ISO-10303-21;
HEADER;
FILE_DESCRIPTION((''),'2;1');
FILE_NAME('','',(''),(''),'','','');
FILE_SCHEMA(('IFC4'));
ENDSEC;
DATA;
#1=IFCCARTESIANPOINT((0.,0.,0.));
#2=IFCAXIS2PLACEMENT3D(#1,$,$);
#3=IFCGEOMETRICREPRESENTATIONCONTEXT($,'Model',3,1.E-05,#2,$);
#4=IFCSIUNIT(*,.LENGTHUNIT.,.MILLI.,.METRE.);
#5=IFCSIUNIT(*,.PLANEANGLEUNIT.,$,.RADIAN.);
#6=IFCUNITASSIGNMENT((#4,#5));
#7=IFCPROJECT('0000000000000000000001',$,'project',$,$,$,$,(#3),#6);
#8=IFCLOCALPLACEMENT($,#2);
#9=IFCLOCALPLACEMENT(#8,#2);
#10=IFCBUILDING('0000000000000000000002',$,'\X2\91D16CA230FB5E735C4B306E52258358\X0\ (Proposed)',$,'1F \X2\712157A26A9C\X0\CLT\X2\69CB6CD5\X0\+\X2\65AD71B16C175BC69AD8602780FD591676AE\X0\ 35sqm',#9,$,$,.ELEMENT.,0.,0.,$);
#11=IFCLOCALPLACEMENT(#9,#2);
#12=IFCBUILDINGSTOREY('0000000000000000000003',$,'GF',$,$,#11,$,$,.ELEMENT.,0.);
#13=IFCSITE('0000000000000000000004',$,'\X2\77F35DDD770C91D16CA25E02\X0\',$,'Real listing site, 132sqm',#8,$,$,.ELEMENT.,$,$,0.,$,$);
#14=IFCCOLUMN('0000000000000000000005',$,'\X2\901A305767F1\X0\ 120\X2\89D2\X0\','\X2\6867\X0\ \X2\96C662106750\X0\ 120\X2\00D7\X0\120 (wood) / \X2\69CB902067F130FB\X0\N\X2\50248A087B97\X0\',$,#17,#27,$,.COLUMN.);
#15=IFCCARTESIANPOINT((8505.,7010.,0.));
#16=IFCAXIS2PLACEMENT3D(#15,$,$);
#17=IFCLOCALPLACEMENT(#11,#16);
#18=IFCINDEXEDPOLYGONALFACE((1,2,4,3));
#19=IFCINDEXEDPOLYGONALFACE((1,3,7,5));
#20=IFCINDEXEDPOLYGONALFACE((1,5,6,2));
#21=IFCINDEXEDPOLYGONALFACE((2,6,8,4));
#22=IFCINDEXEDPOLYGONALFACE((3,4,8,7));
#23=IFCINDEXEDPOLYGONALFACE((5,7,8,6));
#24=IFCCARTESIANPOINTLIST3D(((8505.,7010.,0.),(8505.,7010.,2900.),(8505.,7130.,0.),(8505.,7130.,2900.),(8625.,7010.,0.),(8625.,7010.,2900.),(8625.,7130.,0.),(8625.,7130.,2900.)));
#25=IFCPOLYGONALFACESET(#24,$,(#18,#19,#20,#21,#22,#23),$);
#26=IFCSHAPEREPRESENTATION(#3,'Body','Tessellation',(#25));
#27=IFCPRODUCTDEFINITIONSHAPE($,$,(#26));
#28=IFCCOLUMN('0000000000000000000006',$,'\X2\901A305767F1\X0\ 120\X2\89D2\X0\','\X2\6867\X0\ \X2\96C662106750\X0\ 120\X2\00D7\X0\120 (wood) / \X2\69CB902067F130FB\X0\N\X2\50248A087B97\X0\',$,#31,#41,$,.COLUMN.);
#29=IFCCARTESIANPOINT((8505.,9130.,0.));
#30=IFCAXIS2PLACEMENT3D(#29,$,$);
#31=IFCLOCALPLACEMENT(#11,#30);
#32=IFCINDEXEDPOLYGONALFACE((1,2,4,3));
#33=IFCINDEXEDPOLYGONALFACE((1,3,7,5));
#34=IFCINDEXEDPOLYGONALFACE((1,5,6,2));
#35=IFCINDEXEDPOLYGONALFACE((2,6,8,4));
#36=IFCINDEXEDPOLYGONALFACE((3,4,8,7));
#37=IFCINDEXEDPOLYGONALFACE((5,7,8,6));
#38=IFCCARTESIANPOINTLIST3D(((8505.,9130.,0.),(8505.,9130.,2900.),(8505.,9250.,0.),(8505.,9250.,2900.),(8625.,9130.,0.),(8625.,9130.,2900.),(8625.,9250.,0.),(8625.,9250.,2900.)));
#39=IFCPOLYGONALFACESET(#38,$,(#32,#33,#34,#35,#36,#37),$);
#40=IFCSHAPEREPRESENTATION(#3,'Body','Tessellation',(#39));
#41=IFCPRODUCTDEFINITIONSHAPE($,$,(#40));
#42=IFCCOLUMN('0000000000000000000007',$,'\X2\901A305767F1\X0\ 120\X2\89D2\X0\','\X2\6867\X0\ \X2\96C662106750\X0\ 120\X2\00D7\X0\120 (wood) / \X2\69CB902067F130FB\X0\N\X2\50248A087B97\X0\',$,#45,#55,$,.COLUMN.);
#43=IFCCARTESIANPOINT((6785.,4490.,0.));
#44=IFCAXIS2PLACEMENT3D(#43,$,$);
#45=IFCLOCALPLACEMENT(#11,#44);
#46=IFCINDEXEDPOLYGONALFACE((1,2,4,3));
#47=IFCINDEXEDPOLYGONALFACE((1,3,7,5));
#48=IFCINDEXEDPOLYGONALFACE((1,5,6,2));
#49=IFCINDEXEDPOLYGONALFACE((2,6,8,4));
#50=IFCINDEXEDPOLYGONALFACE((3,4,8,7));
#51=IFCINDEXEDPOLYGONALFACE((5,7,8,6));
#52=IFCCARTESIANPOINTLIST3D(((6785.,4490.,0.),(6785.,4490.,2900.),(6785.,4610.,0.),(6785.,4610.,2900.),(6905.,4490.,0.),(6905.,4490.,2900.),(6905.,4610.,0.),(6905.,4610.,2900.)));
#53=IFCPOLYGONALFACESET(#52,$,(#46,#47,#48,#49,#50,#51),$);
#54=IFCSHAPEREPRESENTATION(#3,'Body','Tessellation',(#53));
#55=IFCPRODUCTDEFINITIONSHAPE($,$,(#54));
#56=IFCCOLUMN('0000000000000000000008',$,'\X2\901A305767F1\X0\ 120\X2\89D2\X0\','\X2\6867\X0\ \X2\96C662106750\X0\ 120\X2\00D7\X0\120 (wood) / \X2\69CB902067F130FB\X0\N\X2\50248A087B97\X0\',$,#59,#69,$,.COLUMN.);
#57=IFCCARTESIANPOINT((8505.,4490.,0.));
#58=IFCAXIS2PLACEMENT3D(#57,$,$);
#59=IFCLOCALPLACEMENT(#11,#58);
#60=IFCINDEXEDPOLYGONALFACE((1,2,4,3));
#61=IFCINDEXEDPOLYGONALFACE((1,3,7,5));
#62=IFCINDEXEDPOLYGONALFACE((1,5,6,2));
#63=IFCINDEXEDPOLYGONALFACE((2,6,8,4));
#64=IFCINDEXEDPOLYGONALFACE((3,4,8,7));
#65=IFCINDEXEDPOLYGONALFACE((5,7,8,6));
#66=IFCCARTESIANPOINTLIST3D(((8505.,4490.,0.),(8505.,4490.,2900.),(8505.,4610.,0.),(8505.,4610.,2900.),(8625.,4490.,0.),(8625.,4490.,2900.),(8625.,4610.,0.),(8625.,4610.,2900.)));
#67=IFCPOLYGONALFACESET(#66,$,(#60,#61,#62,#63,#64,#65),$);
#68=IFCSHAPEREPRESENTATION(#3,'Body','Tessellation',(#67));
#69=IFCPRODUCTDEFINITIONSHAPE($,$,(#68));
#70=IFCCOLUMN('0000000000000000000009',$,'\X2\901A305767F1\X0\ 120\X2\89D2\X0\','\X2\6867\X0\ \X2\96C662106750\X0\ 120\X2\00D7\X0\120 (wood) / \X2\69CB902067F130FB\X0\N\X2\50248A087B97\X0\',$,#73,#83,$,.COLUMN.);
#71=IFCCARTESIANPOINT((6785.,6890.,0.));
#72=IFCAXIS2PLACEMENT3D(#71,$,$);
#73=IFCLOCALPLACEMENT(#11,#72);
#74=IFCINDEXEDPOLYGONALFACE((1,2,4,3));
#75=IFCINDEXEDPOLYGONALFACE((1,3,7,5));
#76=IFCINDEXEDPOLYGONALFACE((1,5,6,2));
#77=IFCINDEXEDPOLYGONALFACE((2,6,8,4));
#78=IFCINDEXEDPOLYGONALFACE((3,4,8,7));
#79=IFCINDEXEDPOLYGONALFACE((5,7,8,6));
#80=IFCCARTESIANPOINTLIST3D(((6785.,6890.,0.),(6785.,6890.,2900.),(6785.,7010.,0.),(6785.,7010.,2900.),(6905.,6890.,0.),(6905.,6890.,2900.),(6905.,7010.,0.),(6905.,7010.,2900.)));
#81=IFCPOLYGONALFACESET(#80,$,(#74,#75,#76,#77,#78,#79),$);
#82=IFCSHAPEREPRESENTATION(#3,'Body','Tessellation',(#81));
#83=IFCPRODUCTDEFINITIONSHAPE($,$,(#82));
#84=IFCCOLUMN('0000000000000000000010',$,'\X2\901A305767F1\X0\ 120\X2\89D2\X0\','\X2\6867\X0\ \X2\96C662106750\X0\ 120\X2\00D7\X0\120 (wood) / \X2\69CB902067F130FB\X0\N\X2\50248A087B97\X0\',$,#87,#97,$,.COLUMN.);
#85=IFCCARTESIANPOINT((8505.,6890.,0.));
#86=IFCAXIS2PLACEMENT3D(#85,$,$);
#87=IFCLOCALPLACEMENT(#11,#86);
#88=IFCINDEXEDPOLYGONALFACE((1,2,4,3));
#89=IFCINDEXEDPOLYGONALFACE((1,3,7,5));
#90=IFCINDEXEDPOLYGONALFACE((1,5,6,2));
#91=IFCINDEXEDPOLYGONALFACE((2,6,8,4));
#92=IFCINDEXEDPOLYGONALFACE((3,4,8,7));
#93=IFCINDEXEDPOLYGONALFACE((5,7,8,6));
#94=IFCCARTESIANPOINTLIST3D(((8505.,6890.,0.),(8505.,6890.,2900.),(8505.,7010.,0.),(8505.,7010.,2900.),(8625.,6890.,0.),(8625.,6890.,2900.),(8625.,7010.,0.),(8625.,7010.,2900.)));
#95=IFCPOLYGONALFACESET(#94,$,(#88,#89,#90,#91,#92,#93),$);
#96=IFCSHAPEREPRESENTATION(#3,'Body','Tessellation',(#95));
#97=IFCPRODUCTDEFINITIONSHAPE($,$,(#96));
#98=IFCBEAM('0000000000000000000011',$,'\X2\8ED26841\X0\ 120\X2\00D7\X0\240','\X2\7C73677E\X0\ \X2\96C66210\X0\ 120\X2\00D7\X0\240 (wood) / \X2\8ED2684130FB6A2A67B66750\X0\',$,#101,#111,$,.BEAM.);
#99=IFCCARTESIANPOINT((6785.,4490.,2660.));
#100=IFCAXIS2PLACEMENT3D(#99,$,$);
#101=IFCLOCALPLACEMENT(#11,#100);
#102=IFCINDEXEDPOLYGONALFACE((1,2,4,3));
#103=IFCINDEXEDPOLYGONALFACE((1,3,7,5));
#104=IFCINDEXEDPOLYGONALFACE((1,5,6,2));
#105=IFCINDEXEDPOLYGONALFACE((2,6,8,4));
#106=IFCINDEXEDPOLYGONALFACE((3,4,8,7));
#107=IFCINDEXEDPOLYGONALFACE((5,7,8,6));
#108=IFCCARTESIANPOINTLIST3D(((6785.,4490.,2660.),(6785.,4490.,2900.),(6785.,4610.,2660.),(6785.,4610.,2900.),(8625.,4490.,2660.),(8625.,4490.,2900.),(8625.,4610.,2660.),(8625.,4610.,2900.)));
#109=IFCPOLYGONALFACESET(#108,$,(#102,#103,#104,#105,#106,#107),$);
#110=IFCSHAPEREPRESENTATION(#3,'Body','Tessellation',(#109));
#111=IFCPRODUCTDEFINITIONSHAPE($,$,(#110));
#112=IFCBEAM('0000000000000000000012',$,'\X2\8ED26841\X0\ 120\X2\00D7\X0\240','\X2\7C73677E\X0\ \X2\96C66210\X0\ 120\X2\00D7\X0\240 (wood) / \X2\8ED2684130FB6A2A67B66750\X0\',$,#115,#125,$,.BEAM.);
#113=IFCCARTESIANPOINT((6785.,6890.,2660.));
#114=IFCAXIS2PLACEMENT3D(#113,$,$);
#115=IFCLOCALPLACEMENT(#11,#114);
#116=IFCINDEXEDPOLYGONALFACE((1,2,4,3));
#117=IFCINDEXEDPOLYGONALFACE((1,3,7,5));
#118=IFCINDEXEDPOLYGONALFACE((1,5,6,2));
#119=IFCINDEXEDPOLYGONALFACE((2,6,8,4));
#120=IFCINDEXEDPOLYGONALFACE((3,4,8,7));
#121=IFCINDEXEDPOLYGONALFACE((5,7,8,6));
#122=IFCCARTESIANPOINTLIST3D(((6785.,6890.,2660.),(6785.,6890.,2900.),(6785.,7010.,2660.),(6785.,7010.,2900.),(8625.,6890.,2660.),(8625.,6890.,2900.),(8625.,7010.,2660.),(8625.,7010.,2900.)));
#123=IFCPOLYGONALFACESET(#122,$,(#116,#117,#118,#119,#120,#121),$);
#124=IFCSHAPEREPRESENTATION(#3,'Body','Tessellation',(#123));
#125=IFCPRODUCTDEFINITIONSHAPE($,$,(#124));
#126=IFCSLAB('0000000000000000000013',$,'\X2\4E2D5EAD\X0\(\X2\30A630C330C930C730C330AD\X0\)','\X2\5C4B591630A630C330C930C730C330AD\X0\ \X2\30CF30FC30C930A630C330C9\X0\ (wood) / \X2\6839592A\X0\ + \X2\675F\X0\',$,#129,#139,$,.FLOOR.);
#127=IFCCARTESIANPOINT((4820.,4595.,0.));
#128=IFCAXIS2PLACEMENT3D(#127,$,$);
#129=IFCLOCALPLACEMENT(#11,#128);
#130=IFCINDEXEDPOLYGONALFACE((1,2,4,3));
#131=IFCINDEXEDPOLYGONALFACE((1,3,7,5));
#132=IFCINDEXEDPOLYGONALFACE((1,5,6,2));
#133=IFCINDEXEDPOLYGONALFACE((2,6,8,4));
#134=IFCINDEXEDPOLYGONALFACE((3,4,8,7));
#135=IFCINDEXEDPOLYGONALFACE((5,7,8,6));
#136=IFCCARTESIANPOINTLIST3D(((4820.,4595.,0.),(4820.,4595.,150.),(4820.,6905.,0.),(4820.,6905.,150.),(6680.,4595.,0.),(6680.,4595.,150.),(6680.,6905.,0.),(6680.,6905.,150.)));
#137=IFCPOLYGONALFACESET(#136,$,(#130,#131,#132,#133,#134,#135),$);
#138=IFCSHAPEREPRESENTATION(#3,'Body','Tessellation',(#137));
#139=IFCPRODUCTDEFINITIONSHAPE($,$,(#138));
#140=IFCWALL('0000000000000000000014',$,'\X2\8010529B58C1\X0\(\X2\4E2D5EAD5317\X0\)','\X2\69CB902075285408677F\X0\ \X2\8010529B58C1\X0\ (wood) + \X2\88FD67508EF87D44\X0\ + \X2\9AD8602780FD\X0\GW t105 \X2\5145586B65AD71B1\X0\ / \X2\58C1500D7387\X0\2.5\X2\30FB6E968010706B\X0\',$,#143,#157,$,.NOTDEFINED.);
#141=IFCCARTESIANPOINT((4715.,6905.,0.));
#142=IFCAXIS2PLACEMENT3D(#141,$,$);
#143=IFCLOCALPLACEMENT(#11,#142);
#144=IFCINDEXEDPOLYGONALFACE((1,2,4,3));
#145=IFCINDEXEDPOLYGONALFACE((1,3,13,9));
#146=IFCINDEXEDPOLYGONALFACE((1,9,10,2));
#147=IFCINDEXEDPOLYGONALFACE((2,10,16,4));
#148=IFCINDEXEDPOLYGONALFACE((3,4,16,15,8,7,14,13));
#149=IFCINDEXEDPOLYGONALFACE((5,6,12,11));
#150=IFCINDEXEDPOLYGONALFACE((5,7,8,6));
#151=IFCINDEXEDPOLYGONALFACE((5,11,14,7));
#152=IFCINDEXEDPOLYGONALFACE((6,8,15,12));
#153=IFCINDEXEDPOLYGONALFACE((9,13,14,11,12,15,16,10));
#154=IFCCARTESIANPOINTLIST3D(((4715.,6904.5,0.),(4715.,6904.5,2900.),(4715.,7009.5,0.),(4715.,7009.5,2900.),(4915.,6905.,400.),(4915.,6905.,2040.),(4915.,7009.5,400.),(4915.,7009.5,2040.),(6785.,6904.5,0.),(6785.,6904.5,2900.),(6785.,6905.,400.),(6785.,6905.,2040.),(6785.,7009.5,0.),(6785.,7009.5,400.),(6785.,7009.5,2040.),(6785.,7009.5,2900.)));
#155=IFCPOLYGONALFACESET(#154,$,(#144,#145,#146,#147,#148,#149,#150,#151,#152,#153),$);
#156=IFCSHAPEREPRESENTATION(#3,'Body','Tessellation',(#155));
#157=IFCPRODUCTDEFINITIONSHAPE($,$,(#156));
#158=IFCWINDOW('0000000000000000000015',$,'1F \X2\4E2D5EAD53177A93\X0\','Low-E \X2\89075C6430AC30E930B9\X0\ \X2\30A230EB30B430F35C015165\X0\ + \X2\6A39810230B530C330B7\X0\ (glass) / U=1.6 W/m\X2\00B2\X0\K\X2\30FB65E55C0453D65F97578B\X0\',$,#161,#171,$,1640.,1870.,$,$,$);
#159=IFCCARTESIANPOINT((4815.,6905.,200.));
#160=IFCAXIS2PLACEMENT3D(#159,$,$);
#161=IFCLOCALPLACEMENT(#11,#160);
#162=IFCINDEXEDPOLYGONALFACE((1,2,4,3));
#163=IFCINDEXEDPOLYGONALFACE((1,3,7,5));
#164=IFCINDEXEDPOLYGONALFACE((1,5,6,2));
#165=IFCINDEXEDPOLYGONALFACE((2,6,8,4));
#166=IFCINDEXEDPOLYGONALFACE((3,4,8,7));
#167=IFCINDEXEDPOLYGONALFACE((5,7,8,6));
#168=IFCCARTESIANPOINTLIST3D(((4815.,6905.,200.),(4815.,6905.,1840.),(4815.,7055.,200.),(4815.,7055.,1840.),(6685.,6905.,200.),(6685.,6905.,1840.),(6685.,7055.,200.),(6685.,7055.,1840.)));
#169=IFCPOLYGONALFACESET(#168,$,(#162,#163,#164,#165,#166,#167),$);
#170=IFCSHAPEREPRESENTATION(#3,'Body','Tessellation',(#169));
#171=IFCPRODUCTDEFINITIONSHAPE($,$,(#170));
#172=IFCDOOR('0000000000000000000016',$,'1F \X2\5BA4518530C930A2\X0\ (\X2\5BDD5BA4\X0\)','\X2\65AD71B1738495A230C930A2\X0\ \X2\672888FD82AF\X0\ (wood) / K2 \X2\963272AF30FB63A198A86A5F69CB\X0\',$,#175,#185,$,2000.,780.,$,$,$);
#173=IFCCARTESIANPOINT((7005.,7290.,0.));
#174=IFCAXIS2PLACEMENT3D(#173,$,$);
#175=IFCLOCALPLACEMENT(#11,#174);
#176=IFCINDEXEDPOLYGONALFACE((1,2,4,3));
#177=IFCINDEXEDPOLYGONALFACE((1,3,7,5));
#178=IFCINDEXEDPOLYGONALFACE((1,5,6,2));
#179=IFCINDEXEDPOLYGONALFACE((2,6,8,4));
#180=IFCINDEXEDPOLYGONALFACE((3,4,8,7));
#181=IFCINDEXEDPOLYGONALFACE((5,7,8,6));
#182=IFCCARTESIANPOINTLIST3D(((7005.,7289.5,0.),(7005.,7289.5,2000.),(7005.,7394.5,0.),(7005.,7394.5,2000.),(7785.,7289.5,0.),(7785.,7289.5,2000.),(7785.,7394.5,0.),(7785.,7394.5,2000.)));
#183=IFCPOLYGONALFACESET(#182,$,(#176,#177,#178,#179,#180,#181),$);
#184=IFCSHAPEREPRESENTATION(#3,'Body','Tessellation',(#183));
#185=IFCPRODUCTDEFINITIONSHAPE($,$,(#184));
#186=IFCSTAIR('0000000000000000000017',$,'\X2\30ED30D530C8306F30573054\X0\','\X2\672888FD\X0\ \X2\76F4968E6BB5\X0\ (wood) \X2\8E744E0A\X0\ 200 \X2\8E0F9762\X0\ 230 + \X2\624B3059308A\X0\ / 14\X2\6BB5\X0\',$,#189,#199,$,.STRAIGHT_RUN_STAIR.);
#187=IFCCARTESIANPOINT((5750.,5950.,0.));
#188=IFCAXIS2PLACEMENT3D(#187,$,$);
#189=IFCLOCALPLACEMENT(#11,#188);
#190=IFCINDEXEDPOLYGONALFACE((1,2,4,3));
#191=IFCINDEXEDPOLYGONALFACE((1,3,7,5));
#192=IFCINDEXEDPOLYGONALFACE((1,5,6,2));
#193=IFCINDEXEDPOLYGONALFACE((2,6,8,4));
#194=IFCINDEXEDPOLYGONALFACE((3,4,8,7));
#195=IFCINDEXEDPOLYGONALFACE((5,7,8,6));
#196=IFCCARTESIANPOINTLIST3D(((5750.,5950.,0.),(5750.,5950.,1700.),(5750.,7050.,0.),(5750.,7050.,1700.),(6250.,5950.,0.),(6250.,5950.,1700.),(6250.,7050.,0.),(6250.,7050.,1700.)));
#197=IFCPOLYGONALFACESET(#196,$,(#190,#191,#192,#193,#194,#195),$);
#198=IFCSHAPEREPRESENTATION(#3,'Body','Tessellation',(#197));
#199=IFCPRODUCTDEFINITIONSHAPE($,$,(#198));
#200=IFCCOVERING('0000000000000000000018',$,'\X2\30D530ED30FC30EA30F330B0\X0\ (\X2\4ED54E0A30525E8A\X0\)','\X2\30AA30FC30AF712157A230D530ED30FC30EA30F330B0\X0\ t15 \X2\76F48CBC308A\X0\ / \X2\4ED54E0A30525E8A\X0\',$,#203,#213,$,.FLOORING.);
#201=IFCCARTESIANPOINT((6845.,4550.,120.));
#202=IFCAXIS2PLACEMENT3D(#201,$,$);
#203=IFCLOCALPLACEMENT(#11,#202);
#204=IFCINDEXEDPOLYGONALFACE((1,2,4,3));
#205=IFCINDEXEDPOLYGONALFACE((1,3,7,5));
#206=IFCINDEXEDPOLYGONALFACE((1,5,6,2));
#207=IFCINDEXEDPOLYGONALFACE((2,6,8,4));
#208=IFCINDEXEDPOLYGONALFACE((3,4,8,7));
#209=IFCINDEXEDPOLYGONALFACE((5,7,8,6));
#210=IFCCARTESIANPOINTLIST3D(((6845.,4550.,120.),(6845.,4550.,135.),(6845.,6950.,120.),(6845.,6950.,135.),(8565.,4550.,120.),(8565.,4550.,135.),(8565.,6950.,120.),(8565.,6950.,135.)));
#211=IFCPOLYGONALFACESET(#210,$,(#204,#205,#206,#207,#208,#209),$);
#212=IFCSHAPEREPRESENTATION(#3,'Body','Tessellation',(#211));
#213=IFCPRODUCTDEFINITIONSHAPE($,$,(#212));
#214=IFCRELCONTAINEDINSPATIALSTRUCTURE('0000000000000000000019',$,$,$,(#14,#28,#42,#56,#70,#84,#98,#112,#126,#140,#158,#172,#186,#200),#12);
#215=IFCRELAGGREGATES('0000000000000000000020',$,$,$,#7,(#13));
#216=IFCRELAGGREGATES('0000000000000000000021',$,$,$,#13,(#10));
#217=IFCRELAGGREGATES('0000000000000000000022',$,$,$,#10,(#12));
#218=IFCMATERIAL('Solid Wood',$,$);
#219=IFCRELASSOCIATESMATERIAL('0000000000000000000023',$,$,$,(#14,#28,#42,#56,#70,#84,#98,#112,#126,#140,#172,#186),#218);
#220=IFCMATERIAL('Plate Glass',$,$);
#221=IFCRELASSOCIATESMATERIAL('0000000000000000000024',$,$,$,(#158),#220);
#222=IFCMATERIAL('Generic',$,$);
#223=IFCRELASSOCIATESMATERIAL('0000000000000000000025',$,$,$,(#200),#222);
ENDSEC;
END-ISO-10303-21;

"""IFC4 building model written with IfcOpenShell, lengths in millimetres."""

from ifc_helpers import new_model, si_unit, frame, frame_2d, origin, place, context, project, spatial, rectangle, extrude, material, element, fill, save


model = new_model("IFC4")

# Units and contexts
model_context = context("Model", 3, precision=1e-05, world=origin())
ifc_project = project(units=[si_unit("LENGTHUNIT", "METRE", prefix="MILLI"), si_unit("PLANEANGLEUNIT", "RADIAN")], contexts=[model_context])

# Site, building, storey
site_placement = place(None, origin())
site = spatial("IfcSite", under=ifc_project, at=site_placement, Name="石川県金沢市", ObjectType="Real listing site, 132sqm", CompositionType="ELEMENT", RefElevation=0.0)
building_placement = place(site_placement, origin())
building = spatial("IfcBuilding", under=site, at=building_placement, Name="金沢・平屋の別荘 (Proposed)", ObjectType="1F 無垢檜CLT構法+断熱気密高性能外皮 35sqm", CompositionType="ELEMENT", ElevationOfRefHeight=0.0, ElevationOfTerrain=0.0)
storey_placement = place(building_placement, origin())
storey = spatial("IfcBuildingStorey", under=building, at=storey_placement, Name="GF", CompositionType="ELEMENT", Elevation=0.0)

# Columns
ifc_material_1 = material(Name="Solid Wood")
column_1_placement = place(storey_placement, frame((8505.0, 7010.0, 0.0)))
element("IfcColumn", 1, at=column_1_placement, inside=storey, material=ifc_material_1, Name="通し柱 120角", Description="桧 集成材 120×120 (wood) / 構造柱・N値計算", PredefinedType="COLUMN", context=model_context, shape_type="SweptSolid", body=[
    extrude(rectangle(XDim=120.0, YDim=120.0, at=frame_2d((60.0, 60.0))), frame((8505.0, 7010.0, 0.0)), (0.0, 0.0, 1.0), 2900.0),
])
column_2_placement = place(storey_placement, frame((8505.0, 9130.0, 0.0)))
element("IfcColumn", 2, at=column_2_placement, inside=storey, material=ifc_material_1, Name="通し柱 120角", Description="桧 集成材 120×120 (wood) / 構造柱・N値計算", PredefinedType="COLUMN", context=model_context, shape_type="SweptSolid", body=[
    extrude(rectangle(XDim=120.0, YDim=120.0, at=frame_2d((60.0, 60.0))), frame((8505.0, 9130.0, 0.0)), (0.0, 0.0, 1.0), 2900.0),
])
column_3_placement = place(storey_placement, frame((6785.0, 4490.0, 0.0)))
element("IfcColumn", 3, at=column_3_placement, inside=storey, material=ifc_material_1, Name="通し柱 120角", Description="桧 集成材 120×120 (wood) / 構造柱・N値計算", PredefinedType="COLUMN", context=model_context, shape_type="SweptSolid", body=[
    extrude(rectangle(XDim=120.0, YDim=120.0, at=frame_2d((60.0, 60.0))), frame((6785.0, 4490.0, 0.0)), (0.0, 0.0, 1.0), 2900.0),
])
column_4_placement = place(storey_placement, frame((8505.0, 4490.0, 0.0)))
element("IfcColumn", 4, at=column_4_placement, inside=storey, material=ifc_material_1, Name="通し柱 120角", Description="桧 集成材 120×120 (wood) / 構造柱・N値計算", PredefinedType="COLUMN", context=model_context, shape_type="SweptSolid", body=[
    extrude(rectangle(XDim=120.0, YDim=120.0, at=frame_2d((60.0, 60.0))), frame((8505.0, 4490.0, 0.0)), (0.0, 0.0, 1.0), 2900.0),
])
column_5_placement = place(storey_placement, frame((6785.0, 6890.0, 0.0)))
element("IfcColumn", 5, at=column_5_placement, inside=storey, material=ifc_material_1, Name="通し柱 120角", Description="桧 集成材 120×120 (wood) / 構造柱・N値計算", PredefinedType="COLUMN", context=model_context, shape_type="SweptSolid", body=[
    extrude(rectangle(XDim=120.0, YDim=120.0, at=frame_2d((60.0, 60.0))), frame((6785.0, 6890.0, 0.0)), (0.0, 0.0, 1.0), 2900.0),
])
column_6_placement = place(storey_placement, frame((8505.0, 6890.0, 0.0)))
element("IfcColumn", 6, at=column_6_placement, inside=storey, material=ifc_material_1, Name="通し柱 120角", Description="桧 集成材 120×120 (wood) / 構造柱・N値計算", PredefinedType="COLUMN", context=model_context, shape_type="SweptSolid", body=[
    extrude(rectangle(XDim=120.0, YDim=120.0, at=frame_2d((60.0, 60.0))), frame((8505.0, 6890.0, 0.0)), (0.0, 0.0, 1.0), 2900.0),
])

# Beams
beam_1_placement = place(storey_placement, frame((6785.0, 4490.0, 2660.0)))
element("IfcBeam", 7, at=beam_1_placement, inside=storey, material=ifc_material_1, Name="軒桁 120×240", Description="米松 集成 120×240 (wood) / 軒桁・横架材", PredefinedType="BEAM", context=model_context, shape_type="SweptSolid", body=[
    extrude(rectangle(XDim=1840.0, YDim=120.0, at=frame_2d((920.0, 60.0))), frame((6785.0, 4490.0, 2660.0)), (0.0, 0.0, 1.0), 240.0),
])
beam_2_placement = place(storey_placement, frame((6785.0, 6890.0, 2660.0)))
element("IfcBeam", 8, at=beam_2_placement, inside=storey, material=ifc_material_1, Name="軒桁 120×240", Description="米松 集成 120×240 (wood) / 軒桁・横架材", PredefinedType="BEAM", context=model_context, shape_type="SweptSolid", body=[
    extrude(rectangle(XDim=1840.0, YDim=120.0, at=frame_2d((920.0, 60.0))), frame((6785.0, 6890.0, 2660.0)), (0.0, 0.0, 1.0), 240.0),
])

# Slab
slab_placement = place(storey_placement, frame((4820.0, 4595.0, 0.0)))
element("IfcSlab", 9, at=slab_placement, inside=storey, material=ifc_material_1, Name="中庭(ウッドデッキ)", Description="屋外ウッドデッキ ハードウッド (wood) / 根太 + 束", PredefinedType="FLOOR", context=model_context, shape_type="SweptSolid", body=[
    extrude(rectangle(XDim=1860.0, YDim=2310.0, at=frame_2d((930.0, 1155.0))), frame((4820.0, 4595.0, 0.0)), (0.0, 0.0, 1.0), 150.0),
])

# Wall, opening, window
wall_1_placement = place(storey_placement, frame((4715.0, 6905.0, 0.0)))
wall_1 = element("IfcWall", 10, at=wall_1_placement, inside=storey, material=ifc_material_1, Name="耐力壁(中庭北)", Description="構造用合板 耐力壁 (wood) + 製材軸組 + 高性能GW t105 充填断熱 / 壁倍率2.5・準耐火", PredefinedType="NOTDEFINED", context=model_context, shape_type="SweptSolid", body=[
    extrude(rectangle(XDim=2070.0, YDim=105.0, at=frame_2d((1035.0, 52.0))), frame((4715.0, 6905.0, 0.0)), (0.0, 0.0, 1.0), 2900.0),
])
opening_placement = place(storey_placement, frame((4815.0, 6905.0, 200.0)))
opening = element("IfcOpeningElement", 11, at=opening_placement, cuts=wall_1, PredefinedType="NOTDEFINED", context=model_context, shape_type="SweptSolid", body=[
    extrude(rectangle(XDim=1870.0, YDim=150.0, at=frame_2d((935.0, 75.0))), frame((4815.0, 6905.0, 200.0)), (0.0, 0.0, 1.0), 1640.0),
])
ifc_material_2 = material(Name="Plate Glass")
window_placement = place(storey_placement, frame((4815.0, 6905.0, 200.0)))
window = element("IfcWindow", 12, at=window_placement, inside=storey, material=ifc_material_2, Name="1F 中庭北窓", Description="Low-E 複層ガラス アルゴン封入 + 樹脂サッシ (glass) / U=1.6 W/m²K・日射取得型", OverallHeight=1640.0, OverallWidth=1870.0, context=model_context, shape_type="SweptSolid", body=[
    extrude(rectangle(XDim=1870.0, YDim=150.0, at=frame_2d((935.0, 75.0))), frame((4815.0, 6905.0, 200.0)), (0.0, 0.0, 1.0), 1640.0),
])
fill(opening, window)

# Door
door_placement = place(storey_placement, frame((7005.0, 7290.0, 0.0)))
element("IfcDoor", 13, at=door_placement, inside=storey, material=ifc_material_1, Name="1F 室内ドア (寝室)", Description="断熱玄関ドア 木製芯 (wood) / K2 防犯・採風機構", OverallHeight=2000.0, OverallWidth=780.0, context=model_context, shape_type="SweptSolid", body=[
    extrude(rectangle(XDim=780.0, YDim=105.0, at=frame_2d((390.0, 52.0))), frame((7005.0, 7290.0, 0.0)), (0.0, 0.0, 1.0), 2000.0),
])

# Stair
stair_placement = place(storey_placement, frame((5750.0, 5950.0, 0.0)))
element("IfcStair", 14, at=stair_placement, inside=storey, material=ifc_material_1, Name="ロフトはしご", Description="木製 直階段 (wood) 蹴上 200 踏面 230 + 手すり / 14段", PredefinedType="STRAIGHT_RUN_STAIR", context=model_context, shape_type="SweptSolid", body=[
    extrude(rectangle(XDim=500.0, YDim=1100.0, at=frame_2d((250.0, 550.0))), frame((5750.0, 5950.0, 0.0)), (0.0, 0.0, 1.0), 1700.0),
])

# Covering
ifc_material_3 = material(Name="Generic")
covering_placement = place(storey_placement, frame((6845.0, 4550.0, 120.0)))
element("IfcCovering", 15, at=covering_placement, inside=storey, material=ifc_material_3, Name="フローリング (仕上げ床)", Description="オーク無垢フローリング t15 直貼り / 仕上げ床", PredefinedType="FLOORING", context=model_context, shape_type="SweptSolid", body=[
    extrude(rectangle(XDim=1720.0, YDim=2400.0, at=frame_2d((860.0, 1200.0))), frame((6845.0, 4550.0, 120.0)), (0.0, 0.0, 1.0), 15.0),
])

save(model, "model.ifc")
